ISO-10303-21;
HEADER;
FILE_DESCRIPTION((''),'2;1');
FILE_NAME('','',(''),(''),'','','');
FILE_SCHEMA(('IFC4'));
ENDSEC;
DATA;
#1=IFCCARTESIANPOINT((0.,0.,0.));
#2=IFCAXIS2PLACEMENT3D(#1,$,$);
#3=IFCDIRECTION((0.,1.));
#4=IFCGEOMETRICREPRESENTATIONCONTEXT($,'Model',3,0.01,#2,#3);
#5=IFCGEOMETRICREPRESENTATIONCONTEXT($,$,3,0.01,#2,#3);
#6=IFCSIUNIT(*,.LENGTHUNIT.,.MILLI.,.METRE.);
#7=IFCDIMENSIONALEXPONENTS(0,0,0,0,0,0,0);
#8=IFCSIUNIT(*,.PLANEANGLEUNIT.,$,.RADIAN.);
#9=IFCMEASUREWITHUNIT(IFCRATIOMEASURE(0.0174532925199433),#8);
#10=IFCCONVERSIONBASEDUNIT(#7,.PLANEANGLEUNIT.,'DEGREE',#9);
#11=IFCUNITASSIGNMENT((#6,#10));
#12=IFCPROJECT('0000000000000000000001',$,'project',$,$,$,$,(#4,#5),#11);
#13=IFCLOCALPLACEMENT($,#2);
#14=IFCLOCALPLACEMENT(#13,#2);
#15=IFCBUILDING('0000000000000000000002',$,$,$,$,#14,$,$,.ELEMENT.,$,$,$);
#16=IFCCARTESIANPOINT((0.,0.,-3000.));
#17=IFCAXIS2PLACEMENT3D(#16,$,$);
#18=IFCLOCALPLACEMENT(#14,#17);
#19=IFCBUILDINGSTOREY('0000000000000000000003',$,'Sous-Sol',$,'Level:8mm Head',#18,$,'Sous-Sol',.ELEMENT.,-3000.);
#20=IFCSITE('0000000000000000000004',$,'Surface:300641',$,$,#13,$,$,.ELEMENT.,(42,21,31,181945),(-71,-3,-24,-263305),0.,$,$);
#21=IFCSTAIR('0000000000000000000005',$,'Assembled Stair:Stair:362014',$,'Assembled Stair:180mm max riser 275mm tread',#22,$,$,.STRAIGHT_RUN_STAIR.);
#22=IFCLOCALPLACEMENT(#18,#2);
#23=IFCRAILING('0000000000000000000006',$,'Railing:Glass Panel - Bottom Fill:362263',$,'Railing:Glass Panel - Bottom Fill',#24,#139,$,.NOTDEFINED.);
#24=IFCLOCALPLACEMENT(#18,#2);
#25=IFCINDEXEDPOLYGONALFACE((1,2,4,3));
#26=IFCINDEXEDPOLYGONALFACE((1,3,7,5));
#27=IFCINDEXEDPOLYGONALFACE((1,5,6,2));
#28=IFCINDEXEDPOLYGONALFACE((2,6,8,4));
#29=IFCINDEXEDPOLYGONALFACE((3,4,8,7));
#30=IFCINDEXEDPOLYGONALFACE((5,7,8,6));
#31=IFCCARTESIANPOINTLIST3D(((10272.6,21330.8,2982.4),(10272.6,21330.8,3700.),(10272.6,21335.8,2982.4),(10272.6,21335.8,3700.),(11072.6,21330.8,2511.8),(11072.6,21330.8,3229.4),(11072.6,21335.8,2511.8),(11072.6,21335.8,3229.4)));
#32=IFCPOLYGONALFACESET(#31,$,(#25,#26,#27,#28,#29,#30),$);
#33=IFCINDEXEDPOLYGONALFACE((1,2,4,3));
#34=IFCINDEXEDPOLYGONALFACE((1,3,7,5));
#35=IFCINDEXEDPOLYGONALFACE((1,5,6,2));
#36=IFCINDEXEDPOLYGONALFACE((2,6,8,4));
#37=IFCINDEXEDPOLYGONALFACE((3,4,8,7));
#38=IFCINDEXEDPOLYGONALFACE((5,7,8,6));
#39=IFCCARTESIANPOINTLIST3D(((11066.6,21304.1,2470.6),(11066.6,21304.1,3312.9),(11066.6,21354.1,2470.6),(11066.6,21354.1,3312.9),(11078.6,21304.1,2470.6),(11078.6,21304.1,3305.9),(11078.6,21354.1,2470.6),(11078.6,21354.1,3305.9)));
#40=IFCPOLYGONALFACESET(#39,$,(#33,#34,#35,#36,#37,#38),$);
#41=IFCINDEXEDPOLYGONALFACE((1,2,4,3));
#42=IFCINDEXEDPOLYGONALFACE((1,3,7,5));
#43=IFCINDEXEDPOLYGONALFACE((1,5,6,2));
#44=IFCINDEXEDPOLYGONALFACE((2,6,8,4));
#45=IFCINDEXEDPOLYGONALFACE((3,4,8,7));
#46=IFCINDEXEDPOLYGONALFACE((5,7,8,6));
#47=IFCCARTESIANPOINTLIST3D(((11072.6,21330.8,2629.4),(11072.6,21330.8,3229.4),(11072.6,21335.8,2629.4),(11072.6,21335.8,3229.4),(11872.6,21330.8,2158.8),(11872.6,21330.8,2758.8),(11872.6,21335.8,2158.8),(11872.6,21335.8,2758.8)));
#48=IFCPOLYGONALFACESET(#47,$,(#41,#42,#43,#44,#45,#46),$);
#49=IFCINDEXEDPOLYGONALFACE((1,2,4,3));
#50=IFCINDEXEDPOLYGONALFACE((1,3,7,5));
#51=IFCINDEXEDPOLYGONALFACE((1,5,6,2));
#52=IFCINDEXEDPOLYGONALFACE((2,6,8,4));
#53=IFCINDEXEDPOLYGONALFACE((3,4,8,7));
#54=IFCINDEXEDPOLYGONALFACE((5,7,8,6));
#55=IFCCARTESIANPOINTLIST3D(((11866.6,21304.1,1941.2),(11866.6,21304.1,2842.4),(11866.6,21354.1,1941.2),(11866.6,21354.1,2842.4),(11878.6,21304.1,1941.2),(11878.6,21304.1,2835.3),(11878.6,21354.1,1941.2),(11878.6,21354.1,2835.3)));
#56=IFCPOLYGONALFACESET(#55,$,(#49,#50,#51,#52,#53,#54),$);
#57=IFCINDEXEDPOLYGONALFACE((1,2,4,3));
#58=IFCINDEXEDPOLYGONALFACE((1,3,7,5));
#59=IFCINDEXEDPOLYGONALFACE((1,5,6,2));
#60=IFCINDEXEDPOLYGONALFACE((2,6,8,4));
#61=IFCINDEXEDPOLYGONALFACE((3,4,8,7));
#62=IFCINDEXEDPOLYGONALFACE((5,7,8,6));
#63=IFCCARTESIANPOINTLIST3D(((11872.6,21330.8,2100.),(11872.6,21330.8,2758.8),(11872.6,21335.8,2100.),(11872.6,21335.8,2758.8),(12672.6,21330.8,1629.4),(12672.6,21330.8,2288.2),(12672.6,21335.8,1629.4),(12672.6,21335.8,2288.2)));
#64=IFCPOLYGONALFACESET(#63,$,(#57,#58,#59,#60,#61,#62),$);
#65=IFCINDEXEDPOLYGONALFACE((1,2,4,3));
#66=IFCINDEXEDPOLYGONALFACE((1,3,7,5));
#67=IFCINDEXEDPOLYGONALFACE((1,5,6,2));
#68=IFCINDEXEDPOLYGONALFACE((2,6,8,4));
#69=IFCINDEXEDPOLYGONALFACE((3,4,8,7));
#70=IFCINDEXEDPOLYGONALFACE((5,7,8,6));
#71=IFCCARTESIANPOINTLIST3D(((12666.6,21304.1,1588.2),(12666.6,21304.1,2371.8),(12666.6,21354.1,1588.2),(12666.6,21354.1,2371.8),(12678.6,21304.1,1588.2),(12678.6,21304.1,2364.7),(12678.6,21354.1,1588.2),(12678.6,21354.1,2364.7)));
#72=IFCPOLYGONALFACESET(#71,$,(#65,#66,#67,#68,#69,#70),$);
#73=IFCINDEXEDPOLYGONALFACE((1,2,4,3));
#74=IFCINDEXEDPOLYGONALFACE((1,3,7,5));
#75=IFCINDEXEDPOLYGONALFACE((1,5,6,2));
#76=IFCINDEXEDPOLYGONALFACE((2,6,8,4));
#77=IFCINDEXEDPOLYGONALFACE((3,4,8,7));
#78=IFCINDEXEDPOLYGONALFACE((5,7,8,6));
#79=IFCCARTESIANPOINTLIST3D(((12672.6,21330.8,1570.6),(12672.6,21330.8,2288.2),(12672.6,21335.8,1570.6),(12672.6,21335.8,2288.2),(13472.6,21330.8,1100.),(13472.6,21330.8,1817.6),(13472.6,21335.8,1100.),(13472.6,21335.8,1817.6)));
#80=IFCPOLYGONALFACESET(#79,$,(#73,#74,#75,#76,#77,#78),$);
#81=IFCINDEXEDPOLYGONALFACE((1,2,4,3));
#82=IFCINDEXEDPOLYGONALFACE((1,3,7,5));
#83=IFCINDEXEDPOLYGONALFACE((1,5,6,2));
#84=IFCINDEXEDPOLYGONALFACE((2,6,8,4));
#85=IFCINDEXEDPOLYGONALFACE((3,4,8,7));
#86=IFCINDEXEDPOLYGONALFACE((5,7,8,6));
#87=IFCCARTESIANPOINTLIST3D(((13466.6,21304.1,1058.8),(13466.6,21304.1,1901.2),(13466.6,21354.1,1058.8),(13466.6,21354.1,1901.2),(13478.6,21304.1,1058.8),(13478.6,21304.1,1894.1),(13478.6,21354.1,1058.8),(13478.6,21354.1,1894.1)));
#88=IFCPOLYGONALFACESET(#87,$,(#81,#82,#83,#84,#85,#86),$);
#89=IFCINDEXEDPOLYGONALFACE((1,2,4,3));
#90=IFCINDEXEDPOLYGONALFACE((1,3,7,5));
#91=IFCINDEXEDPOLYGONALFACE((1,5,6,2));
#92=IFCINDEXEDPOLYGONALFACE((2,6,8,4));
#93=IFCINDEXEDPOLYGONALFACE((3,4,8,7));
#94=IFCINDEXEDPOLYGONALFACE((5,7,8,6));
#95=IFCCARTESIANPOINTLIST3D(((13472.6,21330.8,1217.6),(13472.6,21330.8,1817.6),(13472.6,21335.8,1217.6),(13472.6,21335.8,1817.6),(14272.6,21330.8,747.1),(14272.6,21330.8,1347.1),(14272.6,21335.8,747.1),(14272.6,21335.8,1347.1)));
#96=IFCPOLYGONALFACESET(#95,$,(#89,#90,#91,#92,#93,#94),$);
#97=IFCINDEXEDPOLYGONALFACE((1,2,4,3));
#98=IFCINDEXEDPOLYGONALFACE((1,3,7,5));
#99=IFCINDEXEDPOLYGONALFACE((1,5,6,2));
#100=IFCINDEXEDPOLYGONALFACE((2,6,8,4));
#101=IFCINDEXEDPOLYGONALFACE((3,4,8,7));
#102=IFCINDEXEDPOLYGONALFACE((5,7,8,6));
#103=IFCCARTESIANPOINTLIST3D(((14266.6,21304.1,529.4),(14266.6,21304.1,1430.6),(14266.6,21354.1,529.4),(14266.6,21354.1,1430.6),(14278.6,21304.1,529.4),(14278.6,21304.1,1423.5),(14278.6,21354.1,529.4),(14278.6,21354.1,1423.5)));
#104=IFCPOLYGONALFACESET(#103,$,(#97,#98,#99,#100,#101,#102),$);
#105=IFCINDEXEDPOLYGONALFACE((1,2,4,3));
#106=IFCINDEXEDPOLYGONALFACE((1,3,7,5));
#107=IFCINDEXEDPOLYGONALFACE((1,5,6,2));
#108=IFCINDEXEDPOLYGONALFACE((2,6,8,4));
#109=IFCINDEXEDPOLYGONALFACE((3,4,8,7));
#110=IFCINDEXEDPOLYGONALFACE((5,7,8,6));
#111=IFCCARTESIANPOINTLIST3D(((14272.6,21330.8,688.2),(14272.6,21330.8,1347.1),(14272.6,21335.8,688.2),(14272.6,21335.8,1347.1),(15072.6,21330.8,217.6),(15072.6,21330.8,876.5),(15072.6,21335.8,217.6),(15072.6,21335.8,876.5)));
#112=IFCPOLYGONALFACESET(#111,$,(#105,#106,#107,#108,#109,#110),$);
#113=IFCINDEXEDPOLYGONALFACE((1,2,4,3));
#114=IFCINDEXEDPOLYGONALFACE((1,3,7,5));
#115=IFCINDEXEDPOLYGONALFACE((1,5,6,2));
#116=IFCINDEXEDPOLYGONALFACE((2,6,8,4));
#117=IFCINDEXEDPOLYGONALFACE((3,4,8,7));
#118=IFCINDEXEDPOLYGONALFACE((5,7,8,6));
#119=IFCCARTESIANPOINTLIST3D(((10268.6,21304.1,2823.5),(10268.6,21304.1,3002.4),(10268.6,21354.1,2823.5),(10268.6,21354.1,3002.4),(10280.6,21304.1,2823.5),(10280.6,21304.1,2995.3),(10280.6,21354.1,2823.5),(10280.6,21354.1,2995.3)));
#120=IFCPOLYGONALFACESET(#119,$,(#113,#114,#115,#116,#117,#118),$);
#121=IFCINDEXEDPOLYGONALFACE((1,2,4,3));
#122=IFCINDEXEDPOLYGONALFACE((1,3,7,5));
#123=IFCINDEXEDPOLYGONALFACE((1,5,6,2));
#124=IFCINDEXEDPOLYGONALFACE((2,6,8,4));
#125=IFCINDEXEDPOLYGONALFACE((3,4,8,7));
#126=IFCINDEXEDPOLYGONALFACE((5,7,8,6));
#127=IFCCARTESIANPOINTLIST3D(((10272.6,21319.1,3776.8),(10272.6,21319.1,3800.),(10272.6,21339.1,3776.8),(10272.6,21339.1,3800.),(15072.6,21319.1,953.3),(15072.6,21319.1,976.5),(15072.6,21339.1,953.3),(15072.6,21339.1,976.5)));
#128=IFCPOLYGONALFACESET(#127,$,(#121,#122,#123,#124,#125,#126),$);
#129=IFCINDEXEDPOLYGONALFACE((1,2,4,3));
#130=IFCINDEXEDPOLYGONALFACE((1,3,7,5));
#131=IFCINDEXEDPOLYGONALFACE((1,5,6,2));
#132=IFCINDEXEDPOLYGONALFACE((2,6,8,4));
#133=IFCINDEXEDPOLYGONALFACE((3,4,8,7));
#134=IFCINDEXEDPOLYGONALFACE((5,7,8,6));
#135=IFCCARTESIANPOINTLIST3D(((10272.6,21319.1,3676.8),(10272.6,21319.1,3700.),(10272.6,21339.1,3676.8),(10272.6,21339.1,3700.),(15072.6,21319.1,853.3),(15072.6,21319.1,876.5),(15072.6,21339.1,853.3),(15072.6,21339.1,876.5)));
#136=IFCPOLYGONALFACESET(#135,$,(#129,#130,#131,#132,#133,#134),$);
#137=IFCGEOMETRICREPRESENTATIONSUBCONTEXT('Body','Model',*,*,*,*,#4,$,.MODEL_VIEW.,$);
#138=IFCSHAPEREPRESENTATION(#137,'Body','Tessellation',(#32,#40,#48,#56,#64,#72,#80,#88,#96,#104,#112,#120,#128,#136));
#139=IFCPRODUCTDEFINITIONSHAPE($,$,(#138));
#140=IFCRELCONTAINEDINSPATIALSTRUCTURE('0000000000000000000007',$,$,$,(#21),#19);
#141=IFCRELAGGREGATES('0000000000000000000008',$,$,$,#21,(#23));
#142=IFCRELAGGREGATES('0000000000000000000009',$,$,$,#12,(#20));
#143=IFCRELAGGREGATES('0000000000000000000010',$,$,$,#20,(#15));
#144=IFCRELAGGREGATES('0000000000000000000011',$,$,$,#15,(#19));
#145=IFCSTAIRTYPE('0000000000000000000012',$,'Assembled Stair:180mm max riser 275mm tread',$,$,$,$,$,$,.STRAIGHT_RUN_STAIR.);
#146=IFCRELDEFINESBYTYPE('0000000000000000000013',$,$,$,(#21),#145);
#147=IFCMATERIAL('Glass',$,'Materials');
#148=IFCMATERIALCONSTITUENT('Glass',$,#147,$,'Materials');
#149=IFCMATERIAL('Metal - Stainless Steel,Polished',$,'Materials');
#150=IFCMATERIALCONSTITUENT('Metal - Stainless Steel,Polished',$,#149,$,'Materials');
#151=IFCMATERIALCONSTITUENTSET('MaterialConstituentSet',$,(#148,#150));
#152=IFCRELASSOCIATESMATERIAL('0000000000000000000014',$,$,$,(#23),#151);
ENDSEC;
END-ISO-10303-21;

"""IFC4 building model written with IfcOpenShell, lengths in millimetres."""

from ifc_helpers import new_model, entity, si_unit, converted_unit, direction, frame, origin, place, context, subcontext, project, spatial, polyline, outline, extrude, material, constituent, constituent_set, type_object, element, aggregate, save


model = new_model("IFC4")

# Units and contexts
model_context = context("Model", 3, precision=0.01, world=origin(), true_north=direction((0.0, 1.0)))
context_of_model = context(None, 3, precision=0.01, world=origin(), true_north=direction((0.0, 1.0)))
body_context = subcontext(model_context, "Body", "Model", "MODEL_VIEW")
ifc_project = project(units=[si_unit("LENGTHUNIT", "METRE", prefix="MILLI"), converted_unit("PLANEANGLEUNIT", "DEGREE", entity("IfcRatioMeasure", 0.0174532925199433), si_unit("PLANEANGLEUNIT", "RADIAN"), dimensions=[0, 0, 0, 0, 0, 0, 0])], contexts=[model_context, context_of_model])

# Site, building, storey
site_placement = place(None, origin())
site = spatial("IfcSite", under=ifc_project, at=site_placement, Name="Surface:300641", CompositionType="ELEMENT", RefLatitude=(42, 21, 31, 181945), RefLongitude=(-71, -3, -24, -263305), RefElevation=0.0)
building_placement = place(site_placement, origin())
building = spatial("IfcBuilding", under=site, at=building_placement, CompositionType="ELEMENT")
storey_placement = place(building_placement, frame((0.0, 0.0, -3000.0)))
storey = spatial("IfcBuildingStorey", under=building, at=storey_placement, Name="Sous-Sol", ObjectType="Level:8mm Head", LongName="Sous-Sol", CompositionType="ELEMENT", Elevation=-3000.0)

# Stair
stair_type = type_object("IfcStairType", Name="Assembled Stair:180mm max riser 275mm tread", PredefinedType="STRAIGHT_RUN_STAIR")
stair_placement = place(storey_placement, origin())
stair = element("IfcStair", 1, at=stair_placement, inside=storey, type_object=stair_type, Name="Assembled Stair:Stair:362014", ObjectType="Assembled Stair:180mm max riser 275mm tread", PredefinedType="STRAIGHT_RUN_STAIR")

# Shared definitions
ifc_material_1 = material(Name="Glass", Category="Materials")

# Railing
ifc_constituent_1 = constituent(ifc_material_1, Name="Glass", Category="Materials")
ifc_material_2 = material(Name="Metal - Stainless Steel,Polished", Category="Materials")
ifc_constituent_2 = constituent(ifc_material_2, Name="Metal - Stainless Steel,Polished", Category="Materials")
ifc_constituent_set_1 = constituent_set(constituents=[ifc_constituent_1, ifc_constituent_2], Name="MaterialConstituentSet")
railing_1_placement = place(stair_placement, frame((10268.6, 21304.1, 217.6)))
railing_1 = element("IfcRailing", 2, at=railing_1_placement, material=ifc_constituent_set_1, Name="Railing:Glass Panel - Bottom Fill:362263", ObjectType="Railing:Glass Panel - Bottom Fill", PredefinedType="NOTDEFINED", context=body_context, shape_type="SweptSolid", body=[
    extrude(outline(polyline([(-123.5, -400.0), (594.1, -400.0), (123.5, 400.0), (-594.1, 400.0), (-123.5, -400.0)])), frame((404.0, 26.7, 2888.2), z_axis=(0.0, 1.0, 0.0), x_axis=(0.0, 0.0, -1.0)), (0.0, 0.0, 1.0), 5.0),
    extrude(outline(polyline([(-419.4, -6.0), (422.9, -6.0), (415.9, 6.0), (-419.4, 6.0), (-419.4, -6.0)])), frame((804.0, 0.0, 2672.4), z_axis=(0.0, 1.0, 0.0), x_axis=(0.0, 0.0, 1.0)), (0.0, 0.0, 1.0), 50.0),
    extrude(outline(polyline([(-64.7, -400.0), (535.3, -400.0), (64.7, 400.0), (-535.3, 400.0), (-64.7, -400.0)])), frame((1204.0, 26.7, 2476.5), z_axis=(0.0, 1.0, 0.0), x_axis=(0.0, 0.0, -1.0)), (0.0, 0.0, 1.0), 5.0),
    extrude(outline(polyline([(-448.8, -6.0), (452.4, -6.0), (445.3, 6.0), (-448.8, 6.0), (-448.8, -6.0)])), frame((1604.0, 0.0, 2172.4), z_axis=(0.0, 1.0, 0.0), x_axis=(0.0, 0.0, 1.0)), (0.0, 0.0, 1.0), 50.0),
    extrude(outline(polyline([(-94.1, -400.0), (564.7, -400.0), (94.1, 400.0), (-564.7, 400.0), (-94.1, -400.0)])), frame((2004.0, 26.7, 1976.5), z_axis=(0.0, 1.0, 0.0), x_axis=(0.0, 0.0, -1.0)), (0.0, 0.0, 1.0), 5.0),
    extrude(outline(polyline([(-390.0, -6.0), (393.5, -6.0), (386.5, 6.0), (-390.0, 6.0), (-390.0, -6.0)])), frame((2404.0, 0.0, 1760.6), z_axis=(0.0, 1.0, 0.0), x_axis=(0.0, 0.0, 1.0)), (0.0, 0.0, 1.0), 50.0),
    extrude(outline(polyline([(-123.5, -400.0), (594.1, -400.0), (123.5, 400.0), (-594.1, 400.0), (-123.5, -400.0)])), frame((2804.0, 26.7, 1476.5), z_axis=(0.0, 1.0, 0.0), x_axis=(0.0, 0.0, -1.0)), (0.0, 0.0, 1.0), 5.0),
    extrude(outline(polyline([(-419.4, -6.0), (422.9, -6.0), (415.9, 6.0), (-419.4, 6.0), (-419.4, -6.0)])), frame((3204.0, 0.0, 1260.6), z_axis=(0.0, 1.0, 0.0), x_axis=(0.0, 0.0, 1.0)), (0.0, 0.0, 1.0), 50.0),
    extrude(outline(polyline([(-64.7, -400.0), (535.3, -400.0), (64.7, 400.0), (-535.3, 400.0), (-64.7, -400.0)])), frame((3604.0, 26.7, 1064.7), z_axis=(0.0, 1.0, 0.0), x_axis=(0.0, 0.0, -1.0)), (0.0, 0.0, 1.0), 5.0),
    extrude(outline(polyline([(-448.8, -6.0), (452.4, -6.0), (445.3, 6.0), (-448.8, 6.0), (-448.8, -6.0)])), frame((4004.0, 0.0, 760.6), z_axis=(0.0, 1.0, 0.0), x_axis=(0.0, 0.0, 1.0)), (0.0, 0.0, 1.0), 50.0),
    extrude(outline(polyline([(-94.1, -400.0), (564.7, -400.0), (94.1, 400.0), (-564.7, 400.0), (-94.1, -400.0)])), frame((4404.0, 26.7, 564.7), z_axis=(0.0, 1.0, 0.0), x_axis=(0.0, 0.0, -1.0)), (0.0, 0.0, 1.0), 5.0),
    extrude(outline(polyline([(-87.6, -6.0), (91.2, -6.0), (84.1, 6.0), (-87.6, 6.0), (-87.6, -6.0)])), frame((6.0, 0.0, 2693.5), z_axis=(0.0, 1.0, 0.0), x_axis=(0.0, 0.0, 1.0)), (0.0, 0.0, 1.0), 50.0),
    extrude(outline(polyline([(-2790.3, -10.0), (2778.6, -10.0), (2790.3, 10.0), (-2778.6, 10.0), (-2790.3, -10.0)])), frame((2404.0, 15.0, 2159.0), z_axis=(0.0, 1.0, 0.0), x_axis=(-0.861934, 0.0, 0.50702)), (0.0, 0.0, 1.0), 20.0),
    extrude(outline(polyline([(-2790.3, -10.0), (2778.6, -10.0), (2790.3, 10.0), (-2778.6, 10.0), (-2790.3, -10.0)])), frame((2404.0, 15.0, 2059.0), z_axis=(0.0, 1.0, 0.0), x_axis=(-0.861934, 0.0, 0.50702)), (0.0, 0.0, 1.0), 20.0),
])
aggregate(stair, [railing_1])

save(model, "model.ifc")
